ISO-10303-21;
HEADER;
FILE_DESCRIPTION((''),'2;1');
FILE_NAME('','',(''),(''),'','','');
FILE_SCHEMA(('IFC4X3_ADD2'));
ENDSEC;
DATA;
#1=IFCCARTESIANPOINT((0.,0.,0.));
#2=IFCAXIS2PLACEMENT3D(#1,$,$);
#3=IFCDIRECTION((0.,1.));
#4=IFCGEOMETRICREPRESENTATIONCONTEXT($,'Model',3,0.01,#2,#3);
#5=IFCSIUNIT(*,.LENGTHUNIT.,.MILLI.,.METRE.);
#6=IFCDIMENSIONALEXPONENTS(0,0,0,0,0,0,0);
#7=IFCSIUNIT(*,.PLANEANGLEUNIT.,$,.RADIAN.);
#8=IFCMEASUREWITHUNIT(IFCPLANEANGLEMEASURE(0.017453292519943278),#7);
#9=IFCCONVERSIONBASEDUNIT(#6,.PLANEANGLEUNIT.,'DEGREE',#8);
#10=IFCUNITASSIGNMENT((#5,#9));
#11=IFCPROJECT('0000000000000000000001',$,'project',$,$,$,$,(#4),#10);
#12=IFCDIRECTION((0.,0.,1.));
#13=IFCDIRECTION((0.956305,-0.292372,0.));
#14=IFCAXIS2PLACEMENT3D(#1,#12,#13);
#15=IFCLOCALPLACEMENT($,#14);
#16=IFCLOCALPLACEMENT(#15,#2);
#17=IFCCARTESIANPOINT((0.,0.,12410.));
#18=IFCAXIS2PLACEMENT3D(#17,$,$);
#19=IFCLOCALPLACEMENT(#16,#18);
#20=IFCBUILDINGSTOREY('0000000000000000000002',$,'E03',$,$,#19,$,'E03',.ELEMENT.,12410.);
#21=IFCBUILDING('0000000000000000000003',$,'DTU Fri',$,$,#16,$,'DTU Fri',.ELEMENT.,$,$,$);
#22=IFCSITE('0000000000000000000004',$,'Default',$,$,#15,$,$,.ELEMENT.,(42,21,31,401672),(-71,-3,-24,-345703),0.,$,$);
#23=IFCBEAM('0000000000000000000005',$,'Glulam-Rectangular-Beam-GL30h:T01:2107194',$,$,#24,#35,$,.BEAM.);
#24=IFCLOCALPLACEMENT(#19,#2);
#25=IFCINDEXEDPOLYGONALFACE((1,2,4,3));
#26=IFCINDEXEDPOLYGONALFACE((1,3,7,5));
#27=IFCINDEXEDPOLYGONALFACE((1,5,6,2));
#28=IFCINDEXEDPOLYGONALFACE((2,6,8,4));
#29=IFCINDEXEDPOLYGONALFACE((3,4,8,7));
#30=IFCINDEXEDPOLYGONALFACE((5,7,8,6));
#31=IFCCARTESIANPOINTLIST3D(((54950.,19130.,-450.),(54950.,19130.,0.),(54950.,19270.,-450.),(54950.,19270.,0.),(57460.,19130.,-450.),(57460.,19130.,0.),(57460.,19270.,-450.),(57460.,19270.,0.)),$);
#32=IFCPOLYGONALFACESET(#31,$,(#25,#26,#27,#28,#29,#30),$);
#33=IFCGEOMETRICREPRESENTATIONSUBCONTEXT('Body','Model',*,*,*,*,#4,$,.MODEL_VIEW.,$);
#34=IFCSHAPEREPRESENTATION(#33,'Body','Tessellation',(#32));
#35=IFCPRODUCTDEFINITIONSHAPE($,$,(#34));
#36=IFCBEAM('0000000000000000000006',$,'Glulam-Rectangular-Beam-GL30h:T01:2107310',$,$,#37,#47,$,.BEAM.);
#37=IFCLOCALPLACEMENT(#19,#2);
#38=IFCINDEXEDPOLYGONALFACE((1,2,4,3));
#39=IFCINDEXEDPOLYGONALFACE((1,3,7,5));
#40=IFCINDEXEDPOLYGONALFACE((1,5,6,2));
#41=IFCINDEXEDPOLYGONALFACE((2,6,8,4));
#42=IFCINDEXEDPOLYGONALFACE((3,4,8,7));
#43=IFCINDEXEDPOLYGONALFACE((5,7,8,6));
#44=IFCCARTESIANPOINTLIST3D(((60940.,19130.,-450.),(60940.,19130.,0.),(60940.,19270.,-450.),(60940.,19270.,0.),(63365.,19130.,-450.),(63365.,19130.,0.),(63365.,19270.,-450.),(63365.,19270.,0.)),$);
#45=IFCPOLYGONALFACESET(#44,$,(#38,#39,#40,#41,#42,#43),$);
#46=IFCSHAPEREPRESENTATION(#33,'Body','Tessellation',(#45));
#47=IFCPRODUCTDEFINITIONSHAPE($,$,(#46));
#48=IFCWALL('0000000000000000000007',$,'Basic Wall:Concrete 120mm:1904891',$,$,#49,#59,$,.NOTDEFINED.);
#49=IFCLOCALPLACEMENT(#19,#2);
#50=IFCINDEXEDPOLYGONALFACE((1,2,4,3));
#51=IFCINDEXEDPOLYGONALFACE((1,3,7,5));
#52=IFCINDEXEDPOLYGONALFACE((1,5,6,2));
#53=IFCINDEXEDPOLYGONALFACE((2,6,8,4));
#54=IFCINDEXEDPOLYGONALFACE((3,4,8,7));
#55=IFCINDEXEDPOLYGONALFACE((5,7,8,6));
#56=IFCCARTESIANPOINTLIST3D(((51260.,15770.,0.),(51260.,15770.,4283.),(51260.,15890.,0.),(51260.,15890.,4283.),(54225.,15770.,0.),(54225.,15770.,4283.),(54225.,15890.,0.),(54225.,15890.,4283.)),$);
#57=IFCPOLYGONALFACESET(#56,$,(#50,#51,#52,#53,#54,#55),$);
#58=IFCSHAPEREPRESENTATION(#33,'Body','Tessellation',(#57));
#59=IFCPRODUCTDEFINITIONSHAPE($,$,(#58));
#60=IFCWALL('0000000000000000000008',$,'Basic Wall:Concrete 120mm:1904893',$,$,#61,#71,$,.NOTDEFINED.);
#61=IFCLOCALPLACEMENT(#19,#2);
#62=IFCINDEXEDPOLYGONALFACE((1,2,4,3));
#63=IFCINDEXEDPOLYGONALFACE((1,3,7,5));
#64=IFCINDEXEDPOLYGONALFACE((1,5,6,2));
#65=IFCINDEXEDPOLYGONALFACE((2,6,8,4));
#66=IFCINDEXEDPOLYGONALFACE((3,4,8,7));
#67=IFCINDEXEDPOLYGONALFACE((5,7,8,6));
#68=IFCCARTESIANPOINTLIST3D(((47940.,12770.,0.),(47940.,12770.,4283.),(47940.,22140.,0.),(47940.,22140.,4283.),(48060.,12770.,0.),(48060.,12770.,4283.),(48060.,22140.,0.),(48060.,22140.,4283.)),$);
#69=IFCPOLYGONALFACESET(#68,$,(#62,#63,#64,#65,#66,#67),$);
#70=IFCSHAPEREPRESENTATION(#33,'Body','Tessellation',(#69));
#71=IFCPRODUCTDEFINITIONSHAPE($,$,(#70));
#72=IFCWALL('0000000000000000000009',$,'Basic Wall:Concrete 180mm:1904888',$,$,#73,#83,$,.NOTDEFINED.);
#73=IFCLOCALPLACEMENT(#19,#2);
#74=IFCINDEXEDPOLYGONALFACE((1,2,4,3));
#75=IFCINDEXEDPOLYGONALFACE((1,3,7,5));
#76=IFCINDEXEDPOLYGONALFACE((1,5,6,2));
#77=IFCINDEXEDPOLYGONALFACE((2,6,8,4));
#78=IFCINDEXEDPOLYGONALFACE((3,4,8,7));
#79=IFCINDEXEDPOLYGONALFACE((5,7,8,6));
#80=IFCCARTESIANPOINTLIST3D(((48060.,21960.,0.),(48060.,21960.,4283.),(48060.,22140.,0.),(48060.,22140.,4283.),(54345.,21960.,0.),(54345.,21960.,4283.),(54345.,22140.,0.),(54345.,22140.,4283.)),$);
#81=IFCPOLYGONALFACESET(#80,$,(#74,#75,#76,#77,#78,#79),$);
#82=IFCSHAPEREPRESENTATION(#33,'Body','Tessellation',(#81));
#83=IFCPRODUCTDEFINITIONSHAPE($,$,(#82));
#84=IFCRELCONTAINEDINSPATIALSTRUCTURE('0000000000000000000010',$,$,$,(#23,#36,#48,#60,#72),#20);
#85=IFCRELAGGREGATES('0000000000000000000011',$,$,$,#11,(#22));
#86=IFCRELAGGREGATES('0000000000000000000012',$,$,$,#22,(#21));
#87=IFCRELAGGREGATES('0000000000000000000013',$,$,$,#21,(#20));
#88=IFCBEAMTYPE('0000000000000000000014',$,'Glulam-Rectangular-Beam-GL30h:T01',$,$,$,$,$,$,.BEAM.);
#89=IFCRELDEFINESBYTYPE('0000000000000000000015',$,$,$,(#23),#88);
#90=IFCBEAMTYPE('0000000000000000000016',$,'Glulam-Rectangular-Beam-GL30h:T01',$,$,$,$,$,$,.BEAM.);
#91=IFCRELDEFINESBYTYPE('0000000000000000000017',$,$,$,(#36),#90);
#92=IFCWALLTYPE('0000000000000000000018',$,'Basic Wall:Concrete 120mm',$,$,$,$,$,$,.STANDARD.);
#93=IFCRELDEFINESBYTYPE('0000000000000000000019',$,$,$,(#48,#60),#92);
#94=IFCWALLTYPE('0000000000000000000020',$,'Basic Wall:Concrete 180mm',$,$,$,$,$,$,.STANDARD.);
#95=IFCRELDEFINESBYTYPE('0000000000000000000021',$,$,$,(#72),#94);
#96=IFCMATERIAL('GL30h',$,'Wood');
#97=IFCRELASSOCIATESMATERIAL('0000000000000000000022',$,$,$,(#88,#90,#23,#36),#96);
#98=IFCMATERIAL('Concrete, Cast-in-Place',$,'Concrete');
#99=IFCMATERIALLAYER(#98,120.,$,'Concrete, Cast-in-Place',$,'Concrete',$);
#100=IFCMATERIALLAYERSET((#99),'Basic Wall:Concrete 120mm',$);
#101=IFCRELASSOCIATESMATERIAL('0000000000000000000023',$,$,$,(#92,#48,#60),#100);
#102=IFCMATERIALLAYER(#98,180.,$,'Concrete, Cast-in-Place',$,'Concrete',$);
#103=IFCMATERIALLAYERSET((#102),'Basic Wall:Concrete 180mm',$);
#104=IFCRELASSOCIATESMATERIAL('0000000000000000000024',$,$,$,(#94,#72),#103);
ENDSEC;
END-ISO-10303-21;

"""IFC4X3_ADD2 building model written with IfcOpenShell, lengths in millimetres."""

from ifc_helpers import new_model, entity, si_unit, converted_unit, direction, frame, frame_2d, origin, origin_2d_with_axis, place, context, subcontext, project, spatial, rectangle, extrude, source, transform, mapped, material, layer, layer_set, material_profile, profile_set, profile_usage, type_object, type_shapes, element, save


model = new_model("IFC4X3_ADD2")

# Units and contexts
model_context = context("Model", 3, precision=0.01, world=origin(), true_north=direction((0.0, 1.0)))
body_context = subcontext(model_context, "Body", "Model", "MODEL_VIEW")
ifc_project = project(units=[si_unit("LENGTHUNIT", "METRE", prefix="MILLI"), converted_unit("PLANEANGLEUNIT", "DEGREE", entity("IfcPlaneAngleMeasure", 0.017453292519943278), si_unit("PLANEANGLEUNIT", "RADIAN"), dimensions=[0, 0, 0, 0, 0, 0, 0])], contexts=[model_context])

# Site, building, storey
site_placement = place(None, frame((0.0, 0.0, 0.0), z_axis=(0.0, 0.0, 1.0), x_axis=(0.956305, -0.292372, 0.0)))
site = spatial("IfcSite", under=ifc_project, at=site_placement, Name="Default", CompositionType="ELEMENT", RefLatitude=(42, 21, 31, 401672), RefLongitude=(-71, -3, -24, -345703), RefElevation=0.0)
building_placement = place(site_placement, origin())
building = spatial("IfcBuilding", under=site, at=building_placement, Name="DTU Fri", LongName="DTU Fri", CompositionType="ELEMENT")
storey_placement = place(building_placement, frame((0.0, 0.0, 12410.0)))
storey = spatial("IfcBuildingStorey", under=building, at=storey_placement, Name="E03", LongName="E03", CompositionType="ELEMENT", Elevation=12410.0)

# Shared definitions
ifc_material_1 = material(Name="GL30h", Category="Wood")

# Beams
ifc_material_profile_1 = material_profile(ifc_material_1, rectangle(XDim=450.0, YDim=140.0, at=origin_2d_with_axis()), Name="T01")
ifc_profile_set_1 = profile_set([ifc_material_profile_1], Name="T01")
ifc_profile_usage_1 = profile_usage(ifc_profile_set_1, cardinal=8)
beam_type_1 = type_object("IfcBeamType", Name="Glulam-Rectangular-Beam-GL30h:T01", PredefinedType="BEAM", material=ifc_profile_set_1)
shared_shape_1 = source(origin(), body_context, "Body", "SweptSolid", [
    extrude(rectangle(XDim=450.0, YDim=140.0, at=origin_2d_with_axis()), frame((-1237.5, 0.0, 0.0), z_axis=(1.0, 0.0, 0.0), x_axis=(0.0, 0.0, -1.0)), (0.0, 0.0, 1.0), 2510.0),
])
type_shapes(beam_type_1, [shared_shape_1])
beam_1_placement = place(storey_placement, frame((56187.5, 19200.0, -225.0)))
element("IfcBeam", 1, at=beam_1_placement, inside=storey, type_object=beam_type_1, material=ifc_profile_usage_1, Name="Glulam-Rectangular-Beam-GL30h:T01:2107194", PredefinedType="BEAM", context=body_context, shape_type="MappedRepresentation", body=[
    mapped(shared_shape_1, transform((0.0, 0.0, 0.0), scale=1.0)),
])
beam_type_2 = type_object("IfcBeamType", Name="Glulam-Rectangular-Beam-GL30h:T01", PredefinedType="BEAM", material=ifc_profile_set_1)
shared_shape_2 = source(origin(), body_context, "Body", "SweptSolid", [
    extrude(rectangle(XDim=450.0, YDim=140.0, at=origin_2d_with_axis()), frame((-1230.0, 0.0, 0.0), z_axis=(1.0, 0.0, 0.0), x_axis=(0.0, 0.0, -1.0)), (0.0, 0.0, 1.0), 2425.0),
])
type_shapes(beam_type_2, [shared_shape_2])
beam_2_placement = place(storey_placement, frame((62170.0, 19200.0, -225.0)))
element("IfcBeam", 2, at=beam_2_placement, inside=storey, type_object=beam_type_2, material=ifc_profile_usage_1, Name="Glulam-Rectangular-Beam-GL30h:T01:2107310", PredefinedType="BEAM", context=body_context, shape_type="MappedRepresentation", body=[
    mapped(shared_shape_2, transform((0.0, 0.0, 0.0), scale=1.0)),
])

# Walls
ifc_material_2 = material(Name="Concrete, Cast-in-Place", Category="Concrete")
ifc_layer_1 = layer(ifc_material_2, 120.0, Name="Concrete, Cast-in-Place", Category="Concrete")
ifc_layer_set_1 = layer_set([ifc_layer_1], Name="Basic Wall:Concrete 120mm")
wall_type_1 = type_object("IfcWallType", Name="Basic Wall:Concrete 120mm", PredefinedType="STANDARD", material=ifc_layer_set_1)
wall_1_placement = place(storey_placement, frame((51260.0, 15830.0, 0.0)))
element("IfcWall", 3, at=wall_1_placement, inside=storey, type_object=wall_type_1, material=ifc_layer_set_1, Name="Basic Wall:Concrete 120mm:1904891", PredefinedType="NOTDEFINED", context=body_context, shape_type="SweptSolid", body=[
    extrude(rectangle(XDim=2965.0, YDim=120.0, at=frame_2d((1482.5, 0.0), x_axis=(-1.0, 0.0))), origin(), (0.0, 0.0, 1.0), 4283.0),
])
wall_2_placement = place(storey_placement, frame((48000.0, 22140.0, 0.0), z_axis=(0.0, 0.0, 1.0), x_axis=(0.0, -1.0, 0.0)))
element("IfcWall", 4, at=wall_2_placement, inside=storey, type_object=wall_type_1, material=ifc_layer_set_1, Name="Basic Wall:Concrete 120mm:1904893", PredefinedType="NOTDEFINED", context=body_context, shape_type="SweptSolid", body=[
    extrude(rectangle(XDim=9370.0, YDim=120.0, at=frame_2d((4685.0, 0.0), x_axis=(-1.0, 0.0))), origin(), (0.0, 0.0, 1.0), 4283.0),
])
ifc_layer_2 = layer(ifc_material_2, 180.0, Name="Concrete, Cast-in-Place", Category="Concrete")
ifc_layer_set_2 = layer_set([ifc_layer_2], Name="Basic Wall:Concrete 180mm")
wall_type_2 = type_object("IfcWallType", Name="Basic Wall:Concrete 180mm", PredefinedType="STANDARD", material=ifc_layer_set_2)
wall_3_placement = place(storey_placement, frame((54345.0, 22050.0, 0.0), z_axis=(0.0, 0.0, 1.0), x_axis=(-1.0, 0.0, 0.0)))
element("IfcWall", 5, at=wall_3_placement, inside=storey, type_object=wall_type_2, material=ifc_layer_set_2, Name="Basic Wall:Concrete 180mm:1904888", PredefinedType="NOTDEFINED", context=body_context, shape_type="SweptSolid", body=[
    extrude(rectangle(XDim=6285.0, YDim=180.0, at=frame_2d((3142.5, 0.0), x_axis=(-1.0, 0.0))), origin(), (0.0, 0.0, 1.0), 4283.0),
])

save(model, "model.ifc")
